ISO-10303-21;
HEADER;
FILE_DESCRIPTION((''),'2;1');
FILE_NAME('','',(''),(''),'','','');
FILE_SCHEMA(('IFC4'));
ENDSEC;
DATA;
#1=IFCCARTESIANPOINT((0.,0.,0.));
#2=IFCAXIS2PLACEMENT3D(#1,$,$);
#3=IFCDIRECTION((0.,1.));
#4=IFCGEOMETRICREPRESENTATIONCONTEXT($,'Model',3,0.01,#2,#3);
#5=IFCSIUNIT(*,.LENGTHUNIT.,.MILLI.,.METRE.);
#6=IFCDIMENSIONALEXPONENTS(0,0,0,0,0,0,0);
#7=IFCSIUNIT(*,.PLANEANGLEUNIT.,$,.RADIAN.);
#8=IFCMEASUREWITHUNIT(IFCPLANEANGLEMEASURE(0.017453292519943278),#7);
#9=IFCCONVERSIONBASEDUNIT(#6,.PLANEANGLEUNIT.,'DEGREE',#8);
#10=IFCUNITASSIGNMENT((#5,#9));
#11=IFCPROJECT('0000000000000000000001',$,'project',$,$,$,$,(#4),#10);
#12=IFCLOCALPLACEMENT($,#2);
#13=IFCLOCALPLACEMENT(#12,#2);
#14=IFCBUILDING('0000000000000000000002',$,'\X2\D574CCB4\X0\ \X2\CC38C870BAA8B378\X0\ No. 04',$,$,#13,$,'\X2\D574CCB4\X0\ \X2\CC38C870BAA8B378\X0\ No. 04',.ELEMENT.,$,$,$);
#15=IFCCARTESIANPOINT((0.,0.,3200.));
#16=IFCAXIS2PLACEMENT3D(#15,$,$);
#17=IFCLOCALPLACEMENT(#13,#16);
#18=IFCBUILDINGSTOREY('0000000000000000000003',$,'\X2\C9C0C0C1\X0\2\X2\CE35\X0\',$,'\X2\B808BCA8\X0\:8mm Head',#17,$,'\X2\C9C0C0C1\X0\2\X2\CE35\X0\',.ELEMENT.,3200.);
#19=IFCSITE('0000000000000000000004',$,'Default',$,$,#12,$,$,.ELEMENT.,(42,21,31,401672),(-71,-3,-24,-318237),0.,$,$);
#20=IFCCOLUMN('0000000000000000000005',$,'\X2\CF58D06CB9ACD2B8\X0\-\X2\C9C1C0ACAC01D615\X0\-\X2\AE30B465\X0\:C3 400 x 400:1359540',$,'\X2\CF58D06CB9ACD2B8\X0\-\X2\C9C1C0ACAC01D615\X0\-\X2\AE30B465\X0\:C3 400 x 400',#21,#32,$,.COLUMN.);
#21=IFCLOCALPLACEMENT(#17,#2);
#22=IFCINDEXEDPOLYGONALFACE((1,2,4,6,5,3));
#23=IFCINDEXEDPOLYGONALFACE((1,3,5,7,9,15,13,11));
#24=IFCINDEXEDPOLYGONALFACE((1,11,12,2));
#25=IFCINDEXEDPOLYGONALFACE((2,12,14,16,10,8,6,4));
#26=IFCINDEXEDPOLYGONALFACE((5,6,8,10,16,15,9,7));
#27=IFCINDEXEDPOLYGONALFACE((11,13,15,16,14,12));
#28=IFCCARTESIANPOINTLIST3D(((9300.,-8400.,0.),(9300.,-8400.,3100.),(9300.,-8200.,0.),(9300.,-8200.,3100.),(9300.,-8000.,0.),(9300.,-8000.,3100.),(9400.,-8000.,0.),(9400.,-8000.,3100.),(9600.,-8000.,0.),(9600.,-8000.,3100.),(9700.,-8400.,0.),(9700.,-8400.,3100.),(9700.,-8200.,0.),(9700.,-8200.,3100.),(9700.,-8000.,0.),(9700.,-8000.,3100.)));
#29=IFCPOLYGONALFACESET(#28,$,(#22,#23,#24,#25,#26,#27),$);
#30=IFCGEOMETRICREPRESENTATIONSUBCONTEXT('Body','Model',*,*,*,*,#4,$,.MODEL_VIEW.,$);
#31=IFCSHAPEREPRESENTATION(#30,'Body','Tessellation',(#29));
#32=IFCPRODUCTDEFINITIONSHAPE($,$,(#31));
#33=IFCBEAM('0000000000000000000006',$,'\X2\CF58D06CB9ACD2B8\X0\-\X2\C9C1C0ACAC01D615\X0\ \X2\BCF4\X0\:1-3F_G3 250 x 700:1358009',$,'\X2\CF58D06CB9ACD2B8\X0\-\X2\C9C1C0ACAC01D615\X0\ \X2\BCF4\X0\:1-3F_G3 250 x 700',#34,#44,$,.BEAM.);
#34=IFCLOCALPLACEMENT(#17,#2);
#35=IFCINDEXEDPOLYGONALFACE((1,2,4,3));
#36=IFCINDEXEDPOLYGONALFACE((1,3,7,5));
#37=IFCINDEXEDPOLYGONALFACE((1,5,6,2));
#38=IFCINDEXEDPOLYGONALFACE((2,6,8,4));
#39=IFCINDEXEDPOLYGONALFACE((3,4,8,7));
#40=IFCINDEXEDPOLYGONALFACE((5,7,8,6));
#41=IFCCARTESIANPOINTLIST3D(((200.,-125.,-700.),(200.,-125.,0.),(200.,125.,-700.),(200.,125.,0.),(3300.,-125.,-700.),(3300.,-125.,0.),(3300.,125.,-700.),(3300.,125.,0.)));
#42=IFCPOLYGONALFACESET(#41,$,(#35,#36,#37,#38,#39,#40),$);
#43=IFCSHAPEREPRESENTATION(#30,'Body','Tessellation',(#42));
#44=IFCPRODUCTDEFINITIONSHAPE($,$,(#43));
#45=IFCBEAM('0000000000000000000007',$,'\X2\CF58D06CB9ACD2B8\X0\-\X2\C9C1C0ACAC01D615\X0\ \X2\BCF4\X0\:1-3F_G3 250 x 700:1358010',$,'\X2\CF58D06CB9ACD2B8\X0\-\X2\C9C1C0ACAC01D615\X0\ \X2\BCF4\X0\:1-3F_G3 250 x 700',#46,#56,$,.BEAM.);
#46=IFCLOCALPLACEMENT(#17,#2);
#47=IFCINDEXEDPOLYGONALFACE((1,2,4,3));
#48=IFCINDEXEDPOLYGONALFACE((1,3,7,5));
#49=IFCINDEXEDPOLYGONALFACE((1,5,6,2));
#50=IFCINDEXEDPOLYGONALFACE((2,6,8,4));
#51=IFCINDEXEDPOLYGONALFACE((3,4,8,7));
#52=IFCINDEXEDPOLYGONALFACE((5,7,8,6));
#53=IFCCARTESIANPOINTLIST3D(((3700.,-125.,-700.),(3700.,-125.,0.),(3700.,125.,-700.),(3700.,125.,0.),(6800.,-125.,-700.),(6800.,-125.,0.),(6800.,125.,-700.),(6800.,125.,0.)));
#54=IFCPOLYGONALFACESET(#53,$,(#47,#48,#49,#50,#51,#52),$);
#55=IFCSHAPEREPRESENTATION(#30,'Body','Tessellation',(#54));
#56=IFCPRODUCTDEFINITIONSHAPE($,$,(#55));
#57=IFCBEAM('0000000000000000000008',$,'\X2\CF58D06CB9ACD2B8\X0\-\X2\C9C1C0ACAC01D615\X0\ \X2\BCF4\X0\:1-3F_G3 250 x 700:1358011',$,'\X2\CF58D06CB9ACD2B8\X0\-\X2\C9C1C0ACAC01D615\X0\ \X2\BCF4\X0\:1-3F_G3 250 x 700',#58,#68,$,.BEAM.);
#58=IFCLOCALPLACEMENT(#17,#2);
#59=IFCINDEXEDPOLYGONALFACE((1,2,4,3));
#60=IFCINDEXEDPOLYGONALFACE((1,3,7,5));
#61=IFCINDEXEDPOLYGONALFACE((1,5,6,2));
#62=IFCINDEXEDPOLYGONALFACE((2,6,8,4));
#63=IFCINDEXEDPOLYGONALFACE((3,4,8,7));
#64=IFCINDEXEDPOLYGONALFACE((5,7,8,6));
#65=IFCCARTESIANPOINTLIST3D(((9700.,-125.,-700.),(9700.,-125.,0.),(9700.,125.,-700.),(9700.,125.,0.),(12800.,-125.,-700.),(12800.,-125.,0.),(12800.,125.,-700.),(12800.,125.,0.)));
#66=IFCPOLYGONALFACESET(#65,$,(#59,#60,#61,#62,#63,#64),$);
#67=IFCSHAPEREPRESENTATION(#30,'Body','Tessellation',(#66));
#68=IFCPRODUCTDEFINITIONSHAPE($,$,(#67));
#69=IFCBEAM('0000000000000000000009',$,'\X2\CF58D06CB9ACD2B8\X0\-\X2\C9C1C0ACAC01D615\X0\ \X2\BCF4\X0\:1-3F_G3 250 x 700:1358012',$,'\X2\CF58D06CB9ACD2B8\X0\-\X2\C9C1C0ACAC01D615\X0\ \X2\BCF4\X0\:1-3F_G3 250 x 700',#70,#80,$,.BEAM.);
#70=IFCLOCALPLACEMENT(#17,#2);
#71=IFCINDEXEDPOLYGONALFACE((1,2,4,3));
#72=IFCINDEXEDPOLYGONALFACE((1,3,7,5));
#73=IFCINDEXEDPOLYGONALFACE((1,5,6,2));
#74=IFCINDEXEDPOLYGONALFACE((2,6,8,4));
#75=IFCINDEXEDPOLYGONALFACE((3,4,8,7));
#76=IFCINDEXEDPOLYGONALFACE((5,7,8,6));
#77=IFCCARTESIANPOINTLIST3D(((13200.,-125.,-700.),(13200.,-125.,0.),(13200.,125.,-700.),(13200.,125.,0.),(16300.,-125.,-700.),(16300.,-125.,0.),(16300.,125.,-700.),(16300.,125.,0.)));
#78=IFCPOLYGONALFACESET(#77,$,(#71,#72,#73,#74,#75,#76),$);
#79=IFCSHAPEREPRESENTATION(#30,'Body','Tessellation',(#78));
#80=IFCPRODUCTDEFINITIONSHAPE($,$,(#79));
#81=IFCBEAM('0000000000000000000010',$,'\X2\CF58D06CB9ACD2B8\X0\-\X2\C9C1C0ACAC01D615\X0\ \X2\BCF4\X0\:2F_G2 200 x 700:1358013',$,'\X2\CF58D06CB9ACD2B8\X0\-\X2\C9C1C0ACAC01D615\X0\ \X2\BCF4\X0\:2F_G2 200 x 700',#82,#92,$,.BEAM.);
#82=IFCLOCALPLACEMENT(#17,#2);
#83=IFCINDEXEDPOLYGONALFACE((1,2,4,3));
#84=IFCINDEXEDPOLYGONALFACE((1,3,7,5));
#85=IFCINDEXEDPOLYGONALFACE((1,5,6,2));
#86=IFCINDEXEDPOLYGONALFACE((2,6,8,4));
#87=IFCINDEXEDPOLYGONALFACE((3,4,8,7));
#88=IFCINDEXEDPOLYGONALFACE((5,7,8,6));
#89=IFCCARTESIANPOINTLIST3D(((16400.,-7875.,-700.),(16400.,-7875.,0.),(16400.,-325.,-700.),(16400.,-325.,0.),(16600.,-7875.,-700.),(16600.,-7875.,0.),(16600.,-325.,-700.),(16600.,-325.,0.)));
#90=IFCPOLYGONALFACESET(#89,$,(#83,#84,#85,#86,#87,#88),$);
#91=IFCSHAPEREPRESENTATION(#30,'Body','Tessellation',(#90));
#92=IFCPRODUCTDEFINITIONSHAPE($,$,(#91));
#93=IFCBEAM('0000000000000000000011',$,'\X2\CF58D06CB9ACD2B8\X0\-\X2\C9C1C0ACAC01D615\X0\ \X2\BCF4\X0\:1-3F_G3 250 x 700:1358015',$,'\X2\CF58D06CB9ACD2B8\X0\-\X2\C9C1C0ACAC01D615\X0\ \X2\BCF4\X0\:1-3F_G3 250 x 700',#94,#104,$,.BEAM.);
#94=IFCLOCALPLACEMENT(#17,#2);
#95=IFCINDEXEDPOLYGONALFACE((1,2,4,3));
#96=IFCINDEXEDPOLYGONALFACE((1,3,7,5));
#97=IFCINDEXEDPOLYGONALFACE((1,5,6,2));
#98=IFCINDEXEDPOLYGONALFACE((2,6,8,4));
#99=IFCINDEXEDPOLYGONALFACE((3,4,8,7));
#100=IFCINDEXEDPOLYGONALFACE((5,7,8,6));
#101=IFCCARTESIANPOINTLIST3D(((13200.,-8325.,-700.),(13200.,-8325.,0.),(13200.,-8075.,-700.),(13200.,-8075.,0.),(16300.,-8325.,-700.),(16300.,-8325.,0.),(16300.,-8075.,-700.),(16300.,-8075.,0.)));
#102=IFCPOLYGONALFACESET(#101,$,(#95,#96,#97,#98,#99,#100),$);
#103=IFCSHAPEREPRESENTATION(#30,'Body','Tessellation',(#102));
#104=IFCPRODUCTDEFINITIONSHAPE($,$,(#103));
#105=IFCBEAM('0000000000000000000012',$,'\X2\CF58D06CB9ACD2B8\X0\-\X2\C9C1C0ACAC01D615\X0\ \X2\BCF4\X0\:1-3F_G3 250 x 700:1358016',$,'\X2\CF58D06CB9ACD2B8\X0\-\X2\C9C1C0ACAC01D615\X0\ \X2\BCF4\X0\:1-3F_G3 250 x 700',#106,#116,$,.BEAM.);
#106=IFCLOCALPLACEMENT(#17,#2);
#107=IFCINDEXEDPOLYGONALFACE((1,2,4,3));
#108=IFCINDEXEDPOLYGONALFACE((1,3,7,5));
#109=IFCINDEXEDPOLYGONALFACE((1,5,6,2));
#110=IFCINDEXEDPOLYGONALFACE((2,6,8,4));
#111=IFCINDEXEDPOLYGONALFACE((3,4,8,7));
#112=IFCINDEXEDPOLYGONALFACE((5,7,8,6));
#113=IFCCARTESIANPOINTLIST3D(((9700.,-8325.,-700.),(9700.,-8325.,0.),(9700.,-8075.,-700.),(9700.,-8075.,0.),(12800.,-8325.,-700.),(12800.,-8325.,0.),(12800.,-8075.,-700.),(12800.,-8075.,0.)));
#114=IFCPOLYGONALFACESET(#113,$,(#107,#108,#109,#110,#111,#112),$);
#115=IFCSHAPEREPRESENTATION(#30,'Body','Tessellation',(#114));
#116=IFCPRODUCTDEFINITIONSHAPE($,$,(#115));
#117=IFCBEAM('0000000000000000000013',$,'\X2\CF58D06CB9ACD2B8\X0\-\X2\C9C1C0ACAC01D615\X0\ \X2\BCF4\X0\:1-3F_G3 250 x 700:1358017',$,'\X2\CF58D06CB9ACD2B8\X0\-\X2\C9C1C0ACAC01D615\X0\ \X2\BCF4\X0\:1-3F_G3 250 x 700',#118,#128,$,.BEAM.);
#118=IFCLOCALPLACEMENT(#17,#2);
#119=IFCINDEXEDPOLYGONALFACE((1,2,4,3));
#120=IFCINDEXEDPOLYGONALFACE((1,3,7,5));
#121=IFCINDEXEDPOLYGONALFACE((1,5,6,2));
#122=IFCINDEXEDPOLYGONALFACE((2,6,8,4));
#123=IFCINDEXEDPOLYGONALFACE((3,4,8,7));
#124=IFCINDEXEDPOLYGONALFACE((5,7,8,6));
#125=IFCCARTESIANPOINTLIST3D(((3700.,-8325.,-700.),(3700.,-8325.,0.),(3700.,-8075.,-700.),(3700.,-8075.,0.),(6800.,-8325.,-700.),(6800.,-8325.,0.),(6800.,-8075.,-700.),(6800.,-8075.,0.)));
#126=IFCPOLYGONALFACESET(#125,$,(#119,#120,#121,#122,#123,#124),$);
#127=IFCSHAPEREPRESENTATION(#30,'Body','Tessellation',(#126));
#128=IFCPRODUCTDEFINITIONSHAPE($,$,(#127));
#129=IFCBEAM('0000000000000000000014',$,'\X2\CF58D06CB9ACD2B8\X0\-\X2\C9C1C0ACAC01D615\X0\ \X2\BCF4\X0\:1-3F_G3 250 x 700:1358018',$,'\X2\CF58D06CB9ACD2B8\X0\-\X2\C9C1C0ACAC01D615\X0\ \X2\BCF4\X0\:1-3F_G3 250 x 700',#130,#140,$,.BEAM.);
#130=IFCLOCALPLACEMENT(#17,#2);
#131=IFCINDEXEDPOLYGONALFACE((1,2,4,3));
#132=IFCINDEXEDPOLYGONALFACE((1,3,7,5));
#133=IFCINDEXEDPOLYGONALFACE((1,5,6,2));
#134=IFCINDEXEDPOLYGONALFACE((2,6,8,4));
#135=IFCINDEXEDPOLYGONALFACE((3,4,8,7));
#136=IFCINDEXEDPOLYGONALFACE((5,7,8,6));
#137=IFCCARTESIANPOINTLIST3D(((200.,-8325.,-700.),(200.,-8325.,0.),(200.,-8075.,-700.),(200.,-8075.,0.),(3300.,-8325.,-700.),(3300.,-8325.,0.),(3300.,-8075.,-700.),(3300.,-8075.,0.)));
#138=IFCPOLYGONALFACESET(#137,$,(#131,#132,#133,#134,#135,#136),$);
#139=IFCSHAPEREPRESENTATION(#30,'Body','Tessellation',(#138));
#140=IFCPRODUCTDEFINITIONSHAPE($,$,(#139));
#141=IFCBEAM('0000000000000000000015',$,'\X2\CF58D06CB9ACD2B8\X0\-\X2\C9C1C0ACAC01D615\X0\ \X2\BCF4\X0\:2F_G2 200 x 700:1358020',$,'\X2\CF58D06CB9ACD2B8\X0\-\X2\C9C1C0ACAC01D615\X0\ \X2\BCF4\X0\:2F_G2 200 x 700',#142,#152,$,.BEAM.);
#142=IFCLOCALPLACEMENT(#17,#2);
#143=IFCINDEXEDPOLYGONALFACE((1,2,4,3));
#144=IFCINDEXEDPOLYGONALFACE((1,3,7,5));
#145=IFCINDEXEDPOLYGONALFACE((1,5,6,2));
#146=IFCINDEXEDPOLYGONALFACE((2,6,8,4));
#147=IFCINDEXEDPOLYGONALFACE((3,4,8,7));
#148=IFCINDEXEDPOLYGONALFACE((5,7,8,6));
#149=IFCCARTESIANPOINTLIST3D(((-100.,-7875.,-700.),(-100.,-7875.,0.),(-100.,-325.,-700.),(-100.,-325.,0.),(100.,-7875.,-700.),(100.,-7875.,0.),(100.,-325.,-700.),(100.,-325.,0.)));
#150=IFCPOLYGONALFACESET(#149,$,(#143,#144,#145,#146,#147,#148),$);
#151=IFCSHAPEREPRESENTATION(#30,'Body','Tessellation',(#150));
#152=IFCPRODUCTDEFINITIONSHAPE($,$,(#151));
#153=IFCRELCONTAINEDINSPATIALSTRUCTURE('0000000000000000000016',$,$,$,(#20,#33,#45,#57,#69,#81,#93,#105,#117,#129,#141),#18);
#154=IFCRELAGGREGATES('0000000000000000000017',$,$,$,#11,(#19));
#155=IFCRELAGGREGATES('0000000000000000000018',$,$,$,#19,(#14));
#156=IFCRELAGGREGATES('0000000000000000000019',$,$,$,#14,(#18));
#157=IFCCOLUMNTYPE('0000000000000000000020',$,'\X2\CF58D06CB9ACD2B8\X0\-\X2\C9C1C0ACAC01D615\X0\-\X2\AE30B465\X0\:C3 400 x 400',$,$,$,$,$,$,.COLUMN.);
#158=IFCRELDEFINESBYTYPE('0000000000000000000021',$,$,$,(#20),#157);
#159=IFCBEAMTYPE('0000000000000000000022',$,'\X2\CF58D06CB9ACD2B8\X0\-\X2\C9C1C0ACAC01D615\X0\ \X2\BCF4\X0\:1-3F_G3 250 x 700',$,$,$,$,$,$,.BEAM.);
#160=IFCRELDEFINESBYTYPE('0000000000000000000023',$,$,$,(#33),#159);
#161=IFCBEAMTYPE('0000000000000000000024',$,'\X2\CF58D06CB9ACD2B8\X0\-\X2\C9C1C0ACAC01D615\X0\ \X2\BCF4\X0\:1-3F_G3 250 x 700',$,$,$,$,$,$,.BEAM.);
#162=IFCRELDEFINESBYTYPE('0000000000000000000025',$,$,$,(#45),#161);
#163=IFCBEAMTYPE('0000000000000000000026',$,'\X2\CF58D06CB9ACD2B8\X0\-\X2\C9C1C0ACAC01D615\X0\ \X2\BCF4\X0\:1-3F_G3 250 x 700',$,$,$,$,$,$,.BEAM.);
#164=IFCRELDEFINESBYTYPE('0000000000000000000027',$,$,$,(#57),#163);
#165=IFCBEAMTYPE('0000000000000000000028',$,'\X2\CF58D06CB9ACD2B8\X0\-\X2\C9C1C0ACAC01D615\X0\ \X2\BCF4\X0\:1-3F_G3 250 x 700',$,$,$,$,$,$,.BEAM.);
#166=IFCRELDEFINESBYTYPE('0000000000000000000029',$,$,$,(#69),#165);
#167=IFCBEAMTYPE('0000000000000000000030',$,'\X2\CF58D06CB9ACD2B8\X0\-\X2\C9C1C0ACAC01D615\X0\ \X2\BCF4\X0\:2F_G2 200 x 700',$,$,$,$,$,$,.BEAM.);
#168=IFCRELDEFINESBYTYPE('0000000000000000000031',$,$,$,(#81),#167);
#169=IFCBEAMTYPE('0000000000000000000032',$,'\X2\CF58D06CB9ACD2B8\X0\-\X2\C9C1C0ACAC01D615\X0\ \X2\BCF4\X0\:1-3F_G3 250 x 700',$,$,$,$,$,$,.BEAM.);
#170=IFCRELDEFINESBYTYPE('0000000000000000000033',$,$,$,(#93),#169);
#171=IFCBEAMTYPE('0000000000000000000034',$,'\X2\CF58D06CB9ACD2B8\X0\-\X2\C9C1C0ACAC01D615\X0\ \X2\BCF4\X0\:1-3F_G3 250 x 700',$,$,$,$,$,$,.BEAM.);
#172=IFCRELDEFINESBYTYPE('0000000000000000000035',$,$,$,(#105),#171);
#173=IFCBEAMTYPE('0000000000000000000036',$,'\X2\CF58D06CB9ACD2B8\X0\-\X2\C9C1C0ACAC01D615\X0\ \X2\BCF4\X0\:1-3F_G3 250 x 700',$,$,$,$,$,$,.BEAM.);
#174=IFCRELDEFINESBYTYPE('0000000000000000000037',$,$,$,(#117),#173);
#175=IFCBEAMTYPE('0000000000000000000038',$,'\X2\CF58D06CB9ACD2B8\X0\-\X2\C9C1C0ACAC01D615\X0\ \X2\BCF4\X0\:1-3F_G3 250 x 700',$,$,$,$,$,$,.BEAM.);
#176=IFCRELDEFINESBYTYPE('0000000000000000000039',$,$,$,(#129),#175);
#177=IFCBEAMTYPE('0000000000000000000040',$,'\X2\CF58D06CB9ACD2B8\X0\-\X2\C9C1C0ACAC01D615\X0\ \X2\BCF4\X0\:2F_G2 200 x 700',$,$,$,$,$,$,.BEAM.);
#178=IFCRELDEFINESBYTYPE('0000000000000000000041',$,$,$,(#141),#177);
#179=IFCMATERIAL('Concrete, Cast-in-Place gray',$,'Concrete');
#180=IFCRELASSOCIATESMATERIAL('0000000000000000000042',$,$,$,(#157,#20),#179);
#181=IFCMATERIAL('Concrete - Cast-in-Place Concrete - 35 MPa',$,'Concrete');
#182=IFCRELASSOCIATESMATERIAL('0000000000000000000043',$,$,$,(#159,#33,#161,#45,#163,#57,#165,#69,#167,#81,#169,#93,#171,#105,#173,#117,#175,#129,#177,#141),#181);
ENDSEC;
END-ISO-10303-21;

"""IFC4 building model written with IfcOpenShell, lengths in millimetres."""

from ifc_helpers import new_model, entity, si_unit, converted_unit, direction, frame, origin, place, context, subcontext, project, spatial, indexed_curve, outline, extrude, source, transform, mapped, material, type_object, type_shapes, element, save


model = new_model("IFC4")

# Units and contexts
model_context = context("Model", 3, precision=0.01, world=origin(), true_north=direction((0.0, 1.0)))
body_context = subcontext(model_context, "Body", "Model", "MODEL_VIEW")
ifc_project = project(units=[si_unit("LENGTHUNIT", "METRE", prefix="MILLI"), converted_unit("PLANEANGLEUNIT", "DEGREE", entity("IfcPlaneAngleMeasure", 0.017453292519943278), si_unit("PLANEANGLEUNIT", "RADIAN"), dimensions=[0, 0, 0, 0, 0, 0, 0])], contexts=[model_context])

# Site, building, storey
site_placement = place(None, origin())
site = spatial("IfcSite", under=ifc_project, at=site_placement, Name="Default", CompositionType="ELEMENT", RefLatitude=(42, 21, 31, 401672), RefLongitude=(-71, -3, -24, -318237), RefElevation=0.0)
building_placement = place(site_placement, origin())
building = spatial("IfcBuilding", under=site, at=building_placement, Name="해체 참조모델 No. 04", LongName="해체 참조모델 No. 04", CompositionType="ELEMENT")
storey_placement = place(building_placement, frame((0.0, 0.0, 3200.0)))
storey = spatial("IfcBuildingStorey", under=building, at=storey_placement, Name="지상2층", ObjectType="레벨:8mm Head", LongName="지상2층", CompositionType="ELEMENT", Elevation=3200.0)

# Column
ifc_material_1 = material(Name="Concrete, Cast-in-Place gray", Category="Concrete")
column_type_1 = type_object("IfcColumnType", Name="콘크리트-직사각형-기둥:C3 400 x 400", PredefinedType="COLUMN", material=ifc_material_1)
shared_shape_1 = source(origin(), body_context, "Body", "SweptSolid", [
    extrude(outline(indexed_curve([(-200.0, -150.0), (-100.0, -150.0), (100.0, -150.0), (200.0, -150.0), (200.0, 50.0), (200.0, 250.0), (-200.0, 250.0), (-200.0, 50.0), (-200.0, -150.0)], self_intersect=False)), frame((9500.0, -8150.0, 3200.0), z_axis=(0.0, 0.0, 1.0), x_axis=(-1.0, 0.0, 0.0)), (0.0, 0.0, 1.0), 3100.0),
])
type_shapes(column_type_1, [shared_shape_1])
column_1_placement = place(storey_placement, frame((0.0, 0.0, -3200.0)))
element("IfcColumn", 1, at=column_1_placement, inside=storey, type_object=column_type_1, material=ifc_material_1, Name="콘크리트-직사각형-기둥:C3 400 x 400:1359540", ObjectType="콘크리트-직사각형-기둥:C3 400 x 400", PredefinedType="COLUMN", context=body_context, shape_type="MappedRepresentation", body=[
    mapped(shared_shape_1, transform((0.0, 0.0, 0.0), scale=1.0)),
])

# Beams
ifc_material_2 = material(Name="Concrete - Cast-in-Place Concrete - 35 MPa", Category="Concrete")
beam_type_1 = type_object("IfcBeamType", Name="콘크리트-직사각형 보:1-3F_G3 250 x 700", PredefinedType="BEAM", material=ifc_material_2)
shared_shape_2 = source(origin(), body_context, "Body", "SweptSolid", [
    extrude(outline(indexed_curve([(-350.0, -125.0), (350.0, -125.0), (350.0, 125.0), (-350.0, 125.0), (-350.0, -125.0)], self_intersect=False)), frame((200.0, 0.0, 2850.0), z_axis=(1.0, 0.0, 0.0), x_axis=(0.0, 0.0, -1.0)), (0.0, 0.0, 1.0), 3100.0),
])
type_shapes(beam_type_1, [shared_shape_2])
beam_1_placement = place(storey_placement, frame((0.0, 0.0, -3200.0)))
element("IfcBeam", 2, at=beam_1_placement, inside=storey, type_object=beam_type_1, material=ifc_material_2, Name="콘크리트-직사각형 보:1-3F_G3 250 x 700:1358009", ObjectType="콘크리트-직사각형 보:1-3F_G3 250 x 700", PredefinedType="BEAM", context=body_context, shape_type="MappedRepresentation", body=[
    mapped(shared_shape_2, transform((0.0, 0.0, 0.0), scale=1.0)),
])
beam_type_2 = type_object("IfcBeamType", Name="콘크리트-직사각형 보:1-3F_G3 250 x 700", PredefinedType="BEAM", material=ifc_material_2)
shared_shape_3 = source(origin(), body_context, "Body", "SweptSolid", [
    extrude(outline(indexed_curve([(-350.0, -125.0), (350.0, -125.0), (350.0, 125.0), (-350.0, 125.0), (-350.0, -125.0)], self_intersect=False)), frame((3700.0, 0.0, 2850.0), z_axis=(1.0, 0.0, 0.0), x_axis=(0.0, 0.0, -1.0)), (0.0, 0.0, 1.0), 3100.0),
])
type_shapes(beam_type_2, [shared_shape_3])
beam_2_placement = place(storey_placement, frame((0.0, 0.0, -3200.0)))
element("IfcBeam", 3, at=beam_2_placement, inside=storey, type_object=beam_type_2, material=ifc_material_2, Name="콘크리트-직사각형 보:1-3F_G3 250 x 700:1358010", ObjectType="콘크리트-직사각형 보:1-3F_G3 250 x 700", PredefinedType="BEAM", context=body_context, shape_type="MappedRepresentation", body=[
    mapped(shared_shape_3, transform((0.0, 0.0, 0.0), scale=1.0)),
])
beam_type_3 = type_object("IfcBeamType", Name="콘크리트-직사각형 보:1-3F_G3 250 x 700", PredefinedType="BEAM", material=ifc_material_2)
shared_shape_4 = source(origin(), body_context, "Body", "SweptSolid", [
    extrude(outline(indexed_curve([(-350.0, -125.0), (350.0, -125.0), (350.0, 125.0), (-350.0, 125.0), (-350.0, -125.0)], self_intersect=False)), frame((9700.0, 0.0, 2850.0), z_axis=(1.0, 0.0, 0.0), x_axis=(0.0, 0.0, -1.0)), (0.0, 0.0, 1.0), 3100.0),
])
type_shapes(beam_type_3, [shared_shape_4])
beam_3_placement = place(storey_placement, frame((0.0, 0.0, -3200.0)))
element("IfcBeam", 4, at=beam_3_placement, inside=storey, type_object=beam_type_3, material=ifc_material_2, Name="콘크리트-직사각형 보:1-3F_G3 250 x 700:1358011", ObjectType="콘크리트-직사각형 보:1-3F_G3 250 x 700", PredefinedType="BEAM", context=body_context, shape_type="MappedRepresentation", body=[
    mapped(shared_shape_4, transform((0.0, 0.0, 0.0), scale=1.0)),
])
beam_type_4 = type_object("IfcBeamType", Name="콘크리트-직사각형 보:1-3F_G3 250 x 700", PredefinedType="BEAM", material=ifc_material_2)
shared_shape_5 = source(origin(), body_context, "Body", "SweptSolid", [
    extrude(outline(indexed_curve([(-350.0, -125.0), (350.0, -125.0), (350.0, 125.0), (-350.0, 125.0), (-350.0, -125.0)], self_intersect=False)), frame((13200.0, 0.0, 2850.0), z_axis=(1.0, 0.0, 0.0), x_axis=(0.0, 0.0, -1.0)), (0.0, 0.0, 1.0), 3100.0),
])
type_shapes(beam_type_4, [shared_shape_5])
beam_4_placement = place(storey_placement, frame((0.0, 0.0, -3200.0)))
element("IfcBeam", 5, at=beam_4_placement, inside=storey, type_object=beam_type_4, material=ifc_material_2, Name="콘크리트-직사각형 보:1-3F_G3 250 x 700:1358012", ObjectType="콘크리트-직사각형 보:1-3F_G3 250 x 700", PredefinedType="BEAM", context=body_context, shape_type="MappedRepresentation", body=[
    mapped(shared_shape_5, transform((0.0, 0.0, 0.0), scale=1.0)),
])
beam_type_5 = type_object("IfcBeamType", Name="콘크리트-직사각형 보:2F_G2 200 x 700", PredefinedType="BEAM", material=ifc_material_2)
shared_shape_6 = source(origin(), body_context, "Body", "SweptSolid", [
    extrude(outline(indexed_curve([(-100.0, -350.0), (100.0, -350.0), (100.0, 350.0), (-100.0, 350.0), (-100.0, -350.0)], self_intersect=False)), frame((16500.0, -325.0, 2850.0), z_axis=(0.0, -1.0, 0.0), x_axis=(-1.0, 0.0, 0.0)), (0.0, 0.0, 1.0), 7550.0),
])
type_shapes(beam_type_5, [shared_shape_6])
beam_5_placement = place(storey_placement, frame((0.0, 0.0, -3200.0)))
element("IfcBeam", 6, at=beam_5_placement, inside=storey, type_object=beam_type_5, material=ifc_material_2, Name="콘크리트-직사각형 보:2F_G2 200 x 700:1358013", ObjectType="콘크리트-직사각형 보:2F_G2 200 x 700", PredefinedType="BEAM", context=body_context, shape_type="MappedRepresentation", body=[
    mapped(shared_shape_6, transform((0.0, 0.0, 0.0), scale=1.0)),
])
beam_type_6 = type_object("IfcBeamType", Name="콘크리트-직사각형 보:1-3F_G3 250 x 700", PredefinedType="BEAM", material=ifc_material_2)
shared_shape_7 = source(origin(), body_context, "Body", "SweptSolid", [
    extrude(outline(indexed_curve([(-350.0, -125.0), (350.0, -125.0), (350.0, 125.0), (-350.0, 125.0), (-350.0, -125.0)], self_intersect=False)), frame((16300.0, -8200.0, 2850.0), z_axis=(-1.0, 0.0, 0.0), x_axis=(0.0, 0.0, -1.0)), (0.0, 0.0, 1.0), 3100.0),
])
type_shapes(beam_type_6, [shared_shape_7])
beam_6_placement = place(storey_placement, frame((0.0, 0.0, -3200.0)))
element("IfcBeam", 7, at=beam_6_placement, inside=storey, type_object=beam_type_6, material=ifc_material_2, Name="콘크리트-직사각형 보:1-3F_G3 250 x 700:1358015", ObjectType="콘크리트-직사각형 보:1-3F_G3 250 x 700", PredefinedType="BEAM", context=body_context, shape_type="MappedRepresentation", body=[
    mapped(shared_shape_7, transform((0.0, 0.0, 0.0), scale=1.0)),
])
beam_type_7 = type_object("IfcBeamType", Name="콘크리트-직사각형 보:1-3F_G3 250 x 700", PredefinedType="BEAM", material=ifc_material_2)
shared_shape_8 = source(origin(), body_context, "Body", "SweptSolid", [
    extrude(outline(indexed_curve([(-350.0, -125.0), (350.0, -125.0), (350.0, 125.0), (-350.0, 125.0), (-350.0, -125.0)], self_intersect=False)), frame((12800.0, -8200.0, 2850.0), z_axis=(-1.0, 0.0, 0.0), x_axis=(0.0, 0.0, -1.0)), (0.0, 0.0, 1.0), 3100.0),
])
type_shapes(beam_type_7, [shared_shape_8])
beam_7_placement = place(storey_placement, frame((0.0, 0.0, -3200.0)))
element("IfcBeam", 8, at=beam_7_placement, inside=storey, type_object=beam_type_7, material=ifc_material_2, Name="콘크리트-직사각형 보:1-3F_G3 250 x 700:1358016", ObjectType="콘크리트-직사각형 보:1-3F_G3 250 x 700", PredefinedType="BEAM", context=body_context, shape_type="MappedRepresentation", body=[
    mapped(shared_shape_8, transform((0.0, 0.0, 0.0), scale=1.0)),
])
beam_type_8 = type_object("IfcBeamType", Name="콘크리트-직사각형 보:1-3F_G3 250 x 700", PredefinedType="BEAM", material=ifc_material_2)
shared_shape_9 = source(origin(), body_context, "Body", "SweptSolid", [
    extrude(outline(indexed_curve([(-350.0, -125.0), (350.0, -125.0), (350.0, 125.0), (-350.0, 125.0), (-350.0, -125.0)], self_intersect=False)), frame((6800.0, -8200.0, 2850.0), z_axis=(-1.0, 0.0, 0.0), x_axis=(0.0, 0.0, -1.0)), (0.0, 0.0, 1.0), 3100.0),
])
type_shapes(beam_type_8, [shared_shape_9])
beam_8_placement = place(storey_placement, frame((0.0, 0.0, -3200.0)))
element("IfcBeam", 9, at=beam_8_placement, inside=storey, type_object=beam_type_8, material=ifc_material_2, Name="콘크리트-직사각형 보:1-3F_G3 250 x 700:1358017", ObjectType="콘크리트-직사각형 보:1-3F_G3 250 x 700", PredefinedType="BEAM", context=body_context, shape_type="MappedRepresentation", body=[
    mapped(shared_shape_9, transform((0.0, 0.0, 0.0), scale=1.0)),
])
beam_type_9 = type_object("IfcBeamType", Name="콘크리트-직사각형 보:1-3F_G3 250 x 700", PredefinedType="BEAM", material=ifc_material_2)
shared_shape_10 = source(origin(), body_context, "Body", "SweptSolid", [
    extrude(outline(indexed_curve([(-350.0, -125.0), (350.0, -125.0), (350.0, 125.0), (-350.0, 125.0), (-350.0, -125.0)], self_intersect=False)), frame((3300.0, -8200.0, 2850.0), z_axis=(-1.0, 0.0, 0.0), x_axis=(0.0, 0.0, -1.0)), (0.0, 0.0, 1.0), 3100.0),
])
type_shapes(beam_type_9, [shared_shape_10])
beam_9_placement = place(storey_placement, frame((0.0, 0.0, -3200.0)))
element("IfcBeam", 10, at=beam_9_placement, inside=storey, type_object=beam_type_9, material=ifc_material_2, Name="콘크리트-직사각형 보:1-3F_G3 250 x 700:1358018", ObjectType="콘크리트-직사각형 보:1-3F_G3 250 x 700", PredefinedType="BEAM", context=body_context, shape_type="MappedRepresentation", body=[
    mapped(shared_shape_10, transform((0.0, 0.0, 0.0), scale=1.0)),
])
beam_type_10 = type_object("IfcBeamType", Name="콘크리트-직사각형 보:2F_G2 200 x 700", PredefinedType="BEAM", material=ifc_material_2)
shared_shape_11 = source(origin(), body_context, "Body", "SweptSolid", [
    extrude(outline(indexed_curve([(-100.0, -350.0), (100.0, -350.0), (100.0, 350.0), (-100.0, 350.0), (-100.0, -350.0)], self_intersect=False)), frame((0.0, -7875.0, 2850.0), z_axis=(0.0, 1.0, 0.0), x_axis=(-1.0, 0.0, 0.0)), (0.0, 0.0, 1.0), 7550.0),
])
type_shapes(beam_type_10, [shared_shape_11])
beam_10_placement = place(storey_placement, frame((0.0, 0.0, -3200.0)))
element("IfcBeam", 11, at=beam_10_placement, inside=storey, type_object=beam_type_10, material=ifc_material_2, Name="콘크리트-직사각형 보:2F_G2 200 x 700:1358020", ObjectType="콘크리트-직사각형 보:2F_G2 200 x 700", PredefinedType="BEAM", context=body_context, shape_type="MappedRepresentation", body=[
    mapped(shared_shape_11, transform((0.0, 0.0, 0.0), scale=1.0)),
])

save(model, "model.ifc")
